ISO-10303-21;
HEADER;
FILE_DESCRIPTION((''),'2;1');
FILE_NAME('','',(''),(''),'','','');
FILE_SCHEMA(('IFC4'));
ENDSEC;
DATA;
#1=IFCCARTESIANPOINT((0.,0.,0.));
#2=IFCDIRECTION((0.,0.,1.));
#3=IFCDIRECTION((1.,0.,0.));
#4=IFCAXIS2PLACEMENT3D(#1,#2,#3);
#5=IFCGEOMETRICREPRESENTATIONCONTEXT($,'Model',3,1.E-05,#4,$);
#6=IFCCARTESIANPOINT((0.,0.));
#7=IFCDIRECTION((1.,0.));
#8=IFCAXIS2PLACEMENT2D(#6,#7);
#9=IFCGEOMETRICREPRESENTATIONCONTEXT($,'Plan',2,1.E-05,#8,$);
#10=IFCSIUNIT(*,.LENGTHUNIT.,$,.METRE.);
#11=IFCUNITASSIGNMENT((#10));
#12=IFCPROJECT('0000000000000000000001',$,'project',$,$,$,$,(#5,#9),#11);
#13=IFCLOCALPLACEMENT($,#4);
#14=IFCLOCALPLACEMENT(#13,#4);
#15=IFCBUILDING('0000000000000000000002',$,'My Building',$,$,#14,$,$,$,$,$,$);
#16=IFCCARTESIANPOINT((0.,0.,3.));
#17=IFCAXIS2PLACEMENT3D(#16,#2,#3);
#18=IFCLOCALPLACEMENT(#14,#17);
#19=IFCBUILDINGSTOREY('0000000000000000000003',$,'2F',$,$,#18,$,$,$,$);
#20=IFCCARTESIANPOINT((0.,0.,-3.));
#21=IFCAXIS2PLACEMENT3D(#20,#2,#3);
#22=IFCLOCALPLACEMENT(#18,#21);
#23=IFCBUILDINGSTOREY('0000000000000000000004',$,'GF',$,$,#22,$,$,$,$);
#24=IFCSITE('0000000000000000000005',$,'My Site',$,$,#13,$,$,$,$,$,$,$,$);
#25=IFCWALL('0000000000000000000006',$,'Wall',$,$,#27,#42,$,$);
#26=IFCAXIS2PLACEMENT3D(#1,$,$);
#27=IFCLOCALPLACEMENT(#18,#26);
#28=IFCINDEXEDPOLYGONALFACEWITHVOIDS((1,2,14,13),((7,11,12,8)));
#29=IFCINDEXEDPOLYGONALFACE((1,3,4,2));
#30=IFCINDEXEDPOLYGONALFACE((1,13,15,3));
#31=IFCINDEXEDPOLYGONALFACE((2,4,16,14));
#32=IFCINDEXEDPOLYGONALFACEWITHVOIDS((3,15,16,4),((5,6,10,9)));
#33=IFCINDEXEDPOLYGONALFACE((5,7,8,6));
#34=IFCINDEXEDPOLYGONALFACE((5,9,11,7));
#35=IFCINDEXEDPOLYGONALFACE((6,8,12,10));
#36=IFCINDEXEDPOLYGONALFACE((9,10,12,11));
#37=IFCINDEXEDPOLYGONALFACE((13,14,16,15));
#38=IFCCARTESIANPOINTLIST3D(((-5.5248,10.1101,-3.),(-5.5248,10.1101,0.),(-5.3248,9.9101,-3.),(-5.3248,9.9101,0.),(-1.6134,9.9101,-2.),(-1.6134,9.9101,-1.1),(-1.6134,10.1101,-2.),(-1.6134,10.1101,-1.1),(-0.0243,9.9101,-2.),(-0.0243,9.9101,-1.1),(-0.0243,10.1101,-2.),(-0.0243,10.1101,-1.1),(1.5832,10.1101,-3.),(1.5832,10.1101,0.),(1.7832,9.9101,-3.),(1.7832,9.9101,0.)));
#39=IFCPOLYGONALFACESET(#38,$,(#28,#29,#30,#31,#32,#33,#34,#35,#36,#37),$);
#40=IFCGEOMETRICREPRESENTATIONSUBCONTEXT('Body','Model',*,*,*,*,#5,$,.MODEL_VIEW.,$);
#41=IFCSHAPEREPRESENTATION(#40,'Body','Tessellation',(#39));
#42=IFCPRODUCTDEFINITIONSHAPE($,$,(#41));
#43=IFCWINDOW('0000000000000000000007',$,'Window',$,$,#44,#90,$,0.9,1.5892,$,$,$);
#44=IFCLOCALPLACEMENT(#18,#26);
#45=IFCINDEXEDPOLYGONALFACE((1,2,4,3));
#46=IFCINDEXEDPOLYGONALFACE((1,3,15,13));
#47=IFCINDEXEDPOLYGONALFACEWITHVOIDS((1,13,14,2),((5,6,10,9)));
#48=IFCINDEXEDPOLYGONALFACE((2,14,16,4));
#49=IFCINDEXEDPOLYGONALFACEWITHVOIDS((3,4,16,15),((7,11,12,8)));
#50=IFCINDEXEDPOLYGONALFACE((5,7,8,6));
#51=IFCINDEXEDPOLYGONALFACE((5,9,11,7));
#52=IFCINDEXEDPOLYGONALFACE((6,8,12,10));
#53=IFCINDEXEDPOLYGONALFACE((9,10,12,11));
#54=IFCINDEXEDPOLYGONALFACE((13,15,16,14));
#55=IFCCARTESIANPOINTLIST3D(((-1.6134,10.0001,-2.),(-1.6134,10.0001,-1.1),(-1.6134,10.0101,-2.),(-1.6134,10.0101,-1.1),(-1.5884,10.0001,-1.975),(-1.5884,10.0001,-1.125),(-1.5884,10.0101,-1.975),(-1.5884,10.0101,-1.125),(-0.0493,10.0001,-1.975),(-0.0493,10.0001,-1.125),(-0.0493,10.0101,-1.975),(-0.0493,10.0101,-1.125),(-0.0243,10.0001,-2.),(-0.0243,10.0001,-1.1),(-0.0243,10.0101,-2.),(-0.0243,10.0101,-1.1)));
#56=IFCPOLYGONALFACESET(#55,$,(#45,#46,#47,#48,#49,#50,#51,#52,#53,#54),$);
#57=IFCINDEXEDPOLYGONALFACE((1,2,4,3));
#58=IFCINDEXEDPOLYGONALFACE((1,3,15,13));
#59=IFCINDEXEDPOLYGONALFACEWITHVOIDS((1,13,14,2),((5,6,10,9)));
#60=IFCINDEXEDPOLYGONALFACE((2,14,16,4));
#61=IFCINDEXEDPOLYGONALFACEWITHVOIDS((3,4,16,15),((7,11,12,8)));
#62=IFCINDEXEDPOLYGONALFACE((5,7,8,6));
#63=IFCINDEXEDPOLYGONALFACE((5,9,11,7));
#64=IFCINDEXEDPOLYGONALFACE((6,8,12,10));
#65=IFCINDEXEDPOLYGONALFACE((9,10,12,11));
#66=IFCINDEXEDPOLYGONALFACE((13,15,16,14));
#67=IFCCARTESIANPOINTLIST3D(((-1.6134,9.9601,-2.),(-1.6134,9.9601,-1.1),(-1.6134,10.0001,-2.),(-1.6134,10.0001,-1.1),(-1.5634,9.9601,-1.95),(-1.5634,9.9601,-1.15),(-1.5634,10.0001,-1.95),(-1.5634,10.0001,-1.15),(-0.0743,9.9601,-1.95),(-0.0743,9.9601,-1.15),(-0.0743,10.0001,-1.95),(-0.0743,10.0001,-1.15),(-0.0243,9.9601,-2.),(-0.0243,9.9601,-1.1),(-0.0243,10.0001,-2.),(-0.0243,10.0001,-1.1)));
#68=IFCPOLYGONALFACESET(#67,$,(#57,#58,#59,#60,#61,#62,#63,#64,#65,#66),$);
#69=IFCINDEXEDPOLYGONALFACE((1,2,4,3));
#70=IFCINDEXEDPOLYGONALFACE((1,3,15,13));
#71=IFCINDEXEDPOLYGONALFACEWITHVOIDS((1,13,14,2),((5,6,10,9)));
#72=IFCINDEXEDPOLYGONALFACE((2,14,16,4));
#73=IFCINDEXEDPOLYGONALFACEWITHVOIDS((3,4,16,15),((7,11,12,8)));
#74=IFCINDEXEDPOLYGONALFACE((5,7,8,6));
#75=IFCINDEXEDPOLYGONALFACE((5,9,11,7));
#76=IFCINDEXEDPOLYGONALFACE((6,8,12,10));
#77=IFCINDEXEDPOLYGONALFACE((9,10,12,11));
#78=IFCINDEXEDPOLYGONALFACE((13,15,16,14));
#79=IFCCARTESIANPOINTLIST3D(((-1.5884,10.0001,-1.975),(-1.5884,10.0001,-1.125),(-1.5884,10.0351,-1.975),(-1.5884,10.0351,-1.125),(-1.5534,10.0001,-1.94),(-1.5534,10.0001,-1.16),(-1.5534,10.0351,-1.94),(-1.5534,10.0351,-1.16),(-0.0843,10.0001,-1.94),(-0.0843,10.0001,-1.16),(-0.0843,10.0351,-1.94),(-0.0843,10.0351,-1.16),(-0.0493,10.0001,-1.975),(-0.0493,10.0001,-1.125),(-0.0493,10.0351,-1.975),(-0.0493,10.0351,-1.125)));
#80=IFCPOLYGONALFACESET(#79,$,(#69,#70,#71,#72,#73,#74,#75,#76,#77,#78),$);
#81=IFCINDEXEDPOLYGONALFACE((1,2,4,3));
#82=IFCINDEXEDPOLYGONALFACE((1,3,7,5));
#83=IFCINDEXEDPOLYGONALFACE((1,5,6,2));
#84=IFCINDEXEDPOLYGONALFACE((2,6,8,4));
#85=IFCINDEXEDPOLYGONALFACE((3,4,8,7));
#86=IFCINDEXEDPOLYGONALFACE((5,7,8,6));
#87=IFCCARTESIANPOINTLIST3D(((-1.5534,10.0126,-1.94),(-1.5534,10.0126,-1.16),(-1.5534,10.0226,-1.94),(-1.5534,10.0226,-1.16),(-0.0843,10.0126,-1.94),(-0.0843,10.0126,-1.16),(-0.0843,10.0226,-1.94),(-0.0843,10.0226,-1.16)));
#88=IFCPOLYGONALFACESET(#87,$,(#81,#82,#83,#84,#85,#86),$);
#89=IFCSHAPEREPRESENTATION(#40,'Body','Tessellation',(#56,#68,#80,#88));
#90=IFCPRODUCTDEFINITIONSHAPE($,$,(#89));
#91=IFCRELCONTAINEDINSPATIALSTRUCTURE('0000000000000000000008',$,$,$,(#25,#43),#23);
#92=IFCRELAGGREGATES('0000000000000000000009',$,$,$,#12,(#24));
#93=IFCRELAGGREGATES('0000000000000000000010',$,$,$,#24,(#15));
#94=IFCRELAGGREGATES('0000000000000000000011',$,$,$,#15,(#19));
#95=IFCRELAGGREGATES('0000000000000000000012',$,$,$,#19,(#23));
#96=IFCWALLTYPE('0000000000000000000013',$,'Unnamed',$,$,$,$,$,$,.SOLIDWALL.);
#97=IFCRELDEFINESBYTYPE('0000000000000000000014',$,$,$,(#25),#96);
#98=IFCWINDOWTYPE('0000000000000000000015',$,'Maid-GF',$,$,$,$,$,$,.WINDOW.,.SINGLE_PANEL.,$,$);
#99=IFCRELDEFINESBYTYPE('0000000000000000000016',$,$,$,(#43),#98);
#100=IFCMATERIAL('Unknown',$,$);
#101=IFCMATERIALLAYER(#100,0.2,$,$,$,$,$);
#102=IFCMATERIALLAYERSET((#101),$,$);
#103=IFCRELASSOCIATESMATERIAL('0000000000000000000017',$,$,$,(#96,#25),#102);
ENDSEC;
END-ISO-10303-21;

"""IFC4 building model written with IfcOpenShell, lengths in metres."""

from ifc_helpers import new_model, entity, si_unit, frame, origin_with_axes, origin_2d_with_axis, place, context, subcontext, project, spatial, line, indexed_curve, outline, extrude, shape, source, transform, mapped, material, layer, layer_set, layer_usage, type_object, type_shapes, element, fill, save


model = new_model("IFC4")

# Units and contexts
model_context = context("Model", 3, precision=1e-05, world=origin_with_axes())
plan_context = context("Plan", 2, precision=1e-05, world=origin_2d_with_axis())
body_context_1 = subcontext(model_context, "Body", "Model", "MODEL_VIEW")
body_context_2 = subcontext(plan_context, "Body", "Plan", "PLAN_VIEW")
ifc_project = project(units=[si_unit("LENGTHUNIT", "METRE")], contexts=[model_context, plan_context])

# Site, building, storeys
site_placement = place(None, origin_with_axes())
site = spatial("IfcSite", under=ifc_project, at=site_placement, Name="My Site")
building_placement = place(site_placement, origin_with_axes())
building = spatial("IfcBuilding", under=site, at=building_placement, Name="My Building")
storey_1_placement = place(building_placement, frame((0.0, 0.0, 3.0), z_axis=(0.0, 0.0, 1.0), x_axis=(1.0, 0.0, 0.0)))
storey_1 = spatial("IfcBuildingStorey", under=building, at=storey_1_placement, Name="2F")
storey_2_placement = place(storey_1_placement, frame((0.0, 0.0, -3.0), z_axis=(0.0, 0.0, 1.0), x_axis=(1.0, 0.0, 0.0)))
storey_2 = spatial("IfcBuildingStorey", under=storey_1, at=storey_2_placement, Name="GF")

# Shared definitions
ifc_material = material(Name="Unknown")

# Shared definitions
ifc_layer_1 = layer(ifc_material, 0.2)
ifc_layer_set_1 = layer_set([ifc_layer_1])
wall_type = type_object("IfcWallType", Name="Unnamed", PredefinedType="SOLIDWALL", material=ifc_layer_set_1)

# Wall, opening, window
ifc_layer_usage_1 = layer_usage(ifc_layer_set_1, "AXIS2", "POSITIVE", 0.0)
wall_1_placement = place(storey_2_placement, frame((1.5832, 10.1101, 0.0), z_axis=(0.0, 0.0, 1.0), x_axis=(-1.0, 0.0, 0.0)))
wall_1 = element("IfcWall", 1, at=wall_1_placement, inside=storey_2, type_object=wall_type, material=ifc_layer_usage_1, Name="Wall", context=body_context_1, shape_type="SweptSolid", body=[
    extrude(outline(indexed_curve([(0.0, 0.0), (-0.2, 0.2), (6.908, 0.2), (7.108, 0.0)], segments=[line(1, 2, 3, 4, 1)])), origin_with_axes(), (0.0, 0.0, 1.0), 3.0),
])
shared_shape_1 = source(origin_with_axes(), body_context_1, "Body", "SweptSolid", [
    extrude(outline(indexed_curve([(0.0, 0.0), (1.5892, 0.0), (1.5892, 0.9), (0.0, 0.9)], segments=[line(1, 2, 3, 4, 1)])), frame((0.0, -0.6, 0.0), z_axis=(0.0, -1.0, 0.0), x_axis=(1.0, 0.0, 0.0)), (0.0, 0.0, -1.0), 1.2),
])
opening_1_placement = place(wall_1_placement, frame((3.1967, 0.2, 1.0), z_axis=(0.0, 0.0, 1.0), x_axis=(-1.0, 0.0, 0.0)))
opening_1 = element("IfcOpeningElement", 2, at=opening_1_placement, cuts=wall_1, PredefinedType="OPENING", context=body_context_1, shape_type="MappedRepresentation", body=[
    mapped(shared_shape_1, transform((0.0, 0.0, 0.0), x_axis=(1.0, 0.0, 0.0), y_axis=(0.0, 1.0, 0.0), z_axis=(0.0, 0.0, 1.0), scale=1.0)),
])
window_type_1 = type_object("IfcWindowType", Name="Maid-GF", PartitioningType="SINGLE_PANEL", PredefinedType="WINDOW")
shared_shape_2 = source(origin_with_axes(), body_context_1, "Body", "SweptSolid", [
    extrude(outline(indexed_curve([(0.0, 0.0), (1.5892, 0.0), (1.5892, 0.9), (0.0, 0.9)], segments=[line(1, 2, 3, 4, 1)]), holes=[indexed_curve([(0.025, 0.025), (1.5642, 0.025), (1.5642, 0.875), (0.025, 0.875)], segments=[line(1, 2, 3, 4, 1)])]), frame((0.0, 0.09, 0.0), z_axis=(0.0, -1.0, 0.0), x_axis=(1.0, 0.0, 0.0)), (0.0, 0.0, -1.0), 0.01),
    extrude(outline(indexed_curve([(0.0, 0.0), (1.5892, 0.0), (1.5892, 0.9), (0.0, 0.9)], segments=[line(1, 2, 3, 4, 1)]), holes=[indexed_curve([(0.05, 0.05), (1.5392, 0.05), (1.5392, 0.85), (0.05, 0.85)], segments=[line(1, 2, 3, 4, 1)])]), frame((0.0, 0.05, 0.0), z_axis=(0.0, -1.0, 0.0), x_axis=(1.0, 0.0, 0.0)), (0.0, 0.0, -1.0), 0.04),
    extrude(outline(indexed_curve([(0.0, 0.0), (1.5392, 0.0), (1.5392, 0.85), (0.0, 0.85)], segments=[line(1, 2, 3, 4, 1)]), holes=[indexed_curve([(0.035, 0.035), (1.5042, 0.035), (1.5042, 0.815), (0.035, 0.815)], segments=[line(1, 2, 3, 4, 1)])]), frame((0.025, 0.09, 0.025), z_axis=(0.0, -1.0, 0.0), x_axis=(1.0, 0.0, 0.0)), (0.0, 0.0, -1.0), 0.035),
    extrude(outline(indexed_curve([(0.035, 0.035), (1.5042, 0.035), (1.5042, 0.815), (0.035, 0.815)], segments=[line(1, 2, 3, 4, 1)])), frame((0.025, 0.1025, 0.025), z_axis=(0.0, -1.0, 0.0), x_axis=(1.0, 0.0, 0.0)), (0.0, 0.0, -1.0), 0.01),
])
shared_shape_3 = source(origin_with_axes(), body_context_2, "Body", "Curve2D", [
    entity("IfcIndexedPolyCurve", entity("IfcCartesianPointList2D", [[0.05, 0.05], [1.5392, 0.05]])),
    entity("IfcIndexedPolyCurve", entity("IfcCartesianPointList2D", [[0.0, 0.1], [0.025, 0.1], [0.025, 0.09], [0.05, 0.09], [0.05, 0.05], [0.0, 0.05]]), [entity("IfcLineIndex", [1, 2, 3, 4, 5, 6, 1])]),
    entity("IfcIndexedPolyCurve", entity("IfcCartesianPointList2D", [[1.5892, 0.1], [1.5642, 0.1], [1.5642, 0.09], [1.5392, 0.09], [1.5392, 0.05], [1.5892, 0.05]]), [entity("IfcLineIndex", [1, 2, 3, 4, 5, 6, 1])]),
    entity("IfcIndexedPolyCurve", entity("IfcCartesianPointList2D", [[0.025, 0.09], [0.06, 0.09], [0.06, 0.125], [0.025, 0.125]]), [entity("IfcLineIndex", [1, 2, 3, 4, 1])]),
    entity("IfcIndexedPolyCurve", entity("IfcCartesianPointList2D", [[1.5642, 0.09], [1.5292, 0.09], [1.5292, 0.125], [1.5642, 0.125]]), [entity("IfcLineIndex", [1, 2, 3, 4, 1])]),
    entity("IfcIndexedPolyCurve", entity("IfcCartesianPointList2D", [[0.06, 0.09], [1.5292, 0.09]])),
    entity("IfcIndexedPolyCurve", entity("IfcCartesianPointList2D", [[0.06, 0.125], [1.5292, 0.125]])),
    entity("IfcIndexedPolyCurve", entity("IfcCartesianPointList2D", [[0.06, 0.1075], [1.5292, 0.1075]])),
])
type_shapes(window_type_1, [shared_shape_2, shared_shape_3])
window_1_placement = place(opening_1_placement, frame((0.0, 0.0, 0.0), z_axis=(0.0, 0.0, 1.0), x_axis=(1.0, 0.0, 0.0)))
window_1 = element("IfcWindow", 3, at=window_1_placement, inside=storey_2, type_object=window_type_1, Name="Window", OverallHeight=0.9, OverallWidth=1.5892, shapes=[
    shape(body_context_1, "Body", "MappedRepresentation", [mapped(shared_shape_2, transform((0.0, 0.0, 0.0), x_axis=(1.0, 0.0, 0.0), y_axis=(0.0, 1.0, 0.0), z_axis=(0.0, 0.0, 1.0), scale=1.0))]),
    shape(body_context_2, "Body", "MappedRepresentation", [mapped(shared_shape_3, transform((0.0, 0.0, 0.0), x_axis=(1.0, 0.0, 0.0), y_axis=(0.0, 1.0, 0.0), z_axis=(0.0, 0.0, 1.0), scale=1.0))]),
])
fill(opening_1, window_1)

save(model, "model.ifc")
